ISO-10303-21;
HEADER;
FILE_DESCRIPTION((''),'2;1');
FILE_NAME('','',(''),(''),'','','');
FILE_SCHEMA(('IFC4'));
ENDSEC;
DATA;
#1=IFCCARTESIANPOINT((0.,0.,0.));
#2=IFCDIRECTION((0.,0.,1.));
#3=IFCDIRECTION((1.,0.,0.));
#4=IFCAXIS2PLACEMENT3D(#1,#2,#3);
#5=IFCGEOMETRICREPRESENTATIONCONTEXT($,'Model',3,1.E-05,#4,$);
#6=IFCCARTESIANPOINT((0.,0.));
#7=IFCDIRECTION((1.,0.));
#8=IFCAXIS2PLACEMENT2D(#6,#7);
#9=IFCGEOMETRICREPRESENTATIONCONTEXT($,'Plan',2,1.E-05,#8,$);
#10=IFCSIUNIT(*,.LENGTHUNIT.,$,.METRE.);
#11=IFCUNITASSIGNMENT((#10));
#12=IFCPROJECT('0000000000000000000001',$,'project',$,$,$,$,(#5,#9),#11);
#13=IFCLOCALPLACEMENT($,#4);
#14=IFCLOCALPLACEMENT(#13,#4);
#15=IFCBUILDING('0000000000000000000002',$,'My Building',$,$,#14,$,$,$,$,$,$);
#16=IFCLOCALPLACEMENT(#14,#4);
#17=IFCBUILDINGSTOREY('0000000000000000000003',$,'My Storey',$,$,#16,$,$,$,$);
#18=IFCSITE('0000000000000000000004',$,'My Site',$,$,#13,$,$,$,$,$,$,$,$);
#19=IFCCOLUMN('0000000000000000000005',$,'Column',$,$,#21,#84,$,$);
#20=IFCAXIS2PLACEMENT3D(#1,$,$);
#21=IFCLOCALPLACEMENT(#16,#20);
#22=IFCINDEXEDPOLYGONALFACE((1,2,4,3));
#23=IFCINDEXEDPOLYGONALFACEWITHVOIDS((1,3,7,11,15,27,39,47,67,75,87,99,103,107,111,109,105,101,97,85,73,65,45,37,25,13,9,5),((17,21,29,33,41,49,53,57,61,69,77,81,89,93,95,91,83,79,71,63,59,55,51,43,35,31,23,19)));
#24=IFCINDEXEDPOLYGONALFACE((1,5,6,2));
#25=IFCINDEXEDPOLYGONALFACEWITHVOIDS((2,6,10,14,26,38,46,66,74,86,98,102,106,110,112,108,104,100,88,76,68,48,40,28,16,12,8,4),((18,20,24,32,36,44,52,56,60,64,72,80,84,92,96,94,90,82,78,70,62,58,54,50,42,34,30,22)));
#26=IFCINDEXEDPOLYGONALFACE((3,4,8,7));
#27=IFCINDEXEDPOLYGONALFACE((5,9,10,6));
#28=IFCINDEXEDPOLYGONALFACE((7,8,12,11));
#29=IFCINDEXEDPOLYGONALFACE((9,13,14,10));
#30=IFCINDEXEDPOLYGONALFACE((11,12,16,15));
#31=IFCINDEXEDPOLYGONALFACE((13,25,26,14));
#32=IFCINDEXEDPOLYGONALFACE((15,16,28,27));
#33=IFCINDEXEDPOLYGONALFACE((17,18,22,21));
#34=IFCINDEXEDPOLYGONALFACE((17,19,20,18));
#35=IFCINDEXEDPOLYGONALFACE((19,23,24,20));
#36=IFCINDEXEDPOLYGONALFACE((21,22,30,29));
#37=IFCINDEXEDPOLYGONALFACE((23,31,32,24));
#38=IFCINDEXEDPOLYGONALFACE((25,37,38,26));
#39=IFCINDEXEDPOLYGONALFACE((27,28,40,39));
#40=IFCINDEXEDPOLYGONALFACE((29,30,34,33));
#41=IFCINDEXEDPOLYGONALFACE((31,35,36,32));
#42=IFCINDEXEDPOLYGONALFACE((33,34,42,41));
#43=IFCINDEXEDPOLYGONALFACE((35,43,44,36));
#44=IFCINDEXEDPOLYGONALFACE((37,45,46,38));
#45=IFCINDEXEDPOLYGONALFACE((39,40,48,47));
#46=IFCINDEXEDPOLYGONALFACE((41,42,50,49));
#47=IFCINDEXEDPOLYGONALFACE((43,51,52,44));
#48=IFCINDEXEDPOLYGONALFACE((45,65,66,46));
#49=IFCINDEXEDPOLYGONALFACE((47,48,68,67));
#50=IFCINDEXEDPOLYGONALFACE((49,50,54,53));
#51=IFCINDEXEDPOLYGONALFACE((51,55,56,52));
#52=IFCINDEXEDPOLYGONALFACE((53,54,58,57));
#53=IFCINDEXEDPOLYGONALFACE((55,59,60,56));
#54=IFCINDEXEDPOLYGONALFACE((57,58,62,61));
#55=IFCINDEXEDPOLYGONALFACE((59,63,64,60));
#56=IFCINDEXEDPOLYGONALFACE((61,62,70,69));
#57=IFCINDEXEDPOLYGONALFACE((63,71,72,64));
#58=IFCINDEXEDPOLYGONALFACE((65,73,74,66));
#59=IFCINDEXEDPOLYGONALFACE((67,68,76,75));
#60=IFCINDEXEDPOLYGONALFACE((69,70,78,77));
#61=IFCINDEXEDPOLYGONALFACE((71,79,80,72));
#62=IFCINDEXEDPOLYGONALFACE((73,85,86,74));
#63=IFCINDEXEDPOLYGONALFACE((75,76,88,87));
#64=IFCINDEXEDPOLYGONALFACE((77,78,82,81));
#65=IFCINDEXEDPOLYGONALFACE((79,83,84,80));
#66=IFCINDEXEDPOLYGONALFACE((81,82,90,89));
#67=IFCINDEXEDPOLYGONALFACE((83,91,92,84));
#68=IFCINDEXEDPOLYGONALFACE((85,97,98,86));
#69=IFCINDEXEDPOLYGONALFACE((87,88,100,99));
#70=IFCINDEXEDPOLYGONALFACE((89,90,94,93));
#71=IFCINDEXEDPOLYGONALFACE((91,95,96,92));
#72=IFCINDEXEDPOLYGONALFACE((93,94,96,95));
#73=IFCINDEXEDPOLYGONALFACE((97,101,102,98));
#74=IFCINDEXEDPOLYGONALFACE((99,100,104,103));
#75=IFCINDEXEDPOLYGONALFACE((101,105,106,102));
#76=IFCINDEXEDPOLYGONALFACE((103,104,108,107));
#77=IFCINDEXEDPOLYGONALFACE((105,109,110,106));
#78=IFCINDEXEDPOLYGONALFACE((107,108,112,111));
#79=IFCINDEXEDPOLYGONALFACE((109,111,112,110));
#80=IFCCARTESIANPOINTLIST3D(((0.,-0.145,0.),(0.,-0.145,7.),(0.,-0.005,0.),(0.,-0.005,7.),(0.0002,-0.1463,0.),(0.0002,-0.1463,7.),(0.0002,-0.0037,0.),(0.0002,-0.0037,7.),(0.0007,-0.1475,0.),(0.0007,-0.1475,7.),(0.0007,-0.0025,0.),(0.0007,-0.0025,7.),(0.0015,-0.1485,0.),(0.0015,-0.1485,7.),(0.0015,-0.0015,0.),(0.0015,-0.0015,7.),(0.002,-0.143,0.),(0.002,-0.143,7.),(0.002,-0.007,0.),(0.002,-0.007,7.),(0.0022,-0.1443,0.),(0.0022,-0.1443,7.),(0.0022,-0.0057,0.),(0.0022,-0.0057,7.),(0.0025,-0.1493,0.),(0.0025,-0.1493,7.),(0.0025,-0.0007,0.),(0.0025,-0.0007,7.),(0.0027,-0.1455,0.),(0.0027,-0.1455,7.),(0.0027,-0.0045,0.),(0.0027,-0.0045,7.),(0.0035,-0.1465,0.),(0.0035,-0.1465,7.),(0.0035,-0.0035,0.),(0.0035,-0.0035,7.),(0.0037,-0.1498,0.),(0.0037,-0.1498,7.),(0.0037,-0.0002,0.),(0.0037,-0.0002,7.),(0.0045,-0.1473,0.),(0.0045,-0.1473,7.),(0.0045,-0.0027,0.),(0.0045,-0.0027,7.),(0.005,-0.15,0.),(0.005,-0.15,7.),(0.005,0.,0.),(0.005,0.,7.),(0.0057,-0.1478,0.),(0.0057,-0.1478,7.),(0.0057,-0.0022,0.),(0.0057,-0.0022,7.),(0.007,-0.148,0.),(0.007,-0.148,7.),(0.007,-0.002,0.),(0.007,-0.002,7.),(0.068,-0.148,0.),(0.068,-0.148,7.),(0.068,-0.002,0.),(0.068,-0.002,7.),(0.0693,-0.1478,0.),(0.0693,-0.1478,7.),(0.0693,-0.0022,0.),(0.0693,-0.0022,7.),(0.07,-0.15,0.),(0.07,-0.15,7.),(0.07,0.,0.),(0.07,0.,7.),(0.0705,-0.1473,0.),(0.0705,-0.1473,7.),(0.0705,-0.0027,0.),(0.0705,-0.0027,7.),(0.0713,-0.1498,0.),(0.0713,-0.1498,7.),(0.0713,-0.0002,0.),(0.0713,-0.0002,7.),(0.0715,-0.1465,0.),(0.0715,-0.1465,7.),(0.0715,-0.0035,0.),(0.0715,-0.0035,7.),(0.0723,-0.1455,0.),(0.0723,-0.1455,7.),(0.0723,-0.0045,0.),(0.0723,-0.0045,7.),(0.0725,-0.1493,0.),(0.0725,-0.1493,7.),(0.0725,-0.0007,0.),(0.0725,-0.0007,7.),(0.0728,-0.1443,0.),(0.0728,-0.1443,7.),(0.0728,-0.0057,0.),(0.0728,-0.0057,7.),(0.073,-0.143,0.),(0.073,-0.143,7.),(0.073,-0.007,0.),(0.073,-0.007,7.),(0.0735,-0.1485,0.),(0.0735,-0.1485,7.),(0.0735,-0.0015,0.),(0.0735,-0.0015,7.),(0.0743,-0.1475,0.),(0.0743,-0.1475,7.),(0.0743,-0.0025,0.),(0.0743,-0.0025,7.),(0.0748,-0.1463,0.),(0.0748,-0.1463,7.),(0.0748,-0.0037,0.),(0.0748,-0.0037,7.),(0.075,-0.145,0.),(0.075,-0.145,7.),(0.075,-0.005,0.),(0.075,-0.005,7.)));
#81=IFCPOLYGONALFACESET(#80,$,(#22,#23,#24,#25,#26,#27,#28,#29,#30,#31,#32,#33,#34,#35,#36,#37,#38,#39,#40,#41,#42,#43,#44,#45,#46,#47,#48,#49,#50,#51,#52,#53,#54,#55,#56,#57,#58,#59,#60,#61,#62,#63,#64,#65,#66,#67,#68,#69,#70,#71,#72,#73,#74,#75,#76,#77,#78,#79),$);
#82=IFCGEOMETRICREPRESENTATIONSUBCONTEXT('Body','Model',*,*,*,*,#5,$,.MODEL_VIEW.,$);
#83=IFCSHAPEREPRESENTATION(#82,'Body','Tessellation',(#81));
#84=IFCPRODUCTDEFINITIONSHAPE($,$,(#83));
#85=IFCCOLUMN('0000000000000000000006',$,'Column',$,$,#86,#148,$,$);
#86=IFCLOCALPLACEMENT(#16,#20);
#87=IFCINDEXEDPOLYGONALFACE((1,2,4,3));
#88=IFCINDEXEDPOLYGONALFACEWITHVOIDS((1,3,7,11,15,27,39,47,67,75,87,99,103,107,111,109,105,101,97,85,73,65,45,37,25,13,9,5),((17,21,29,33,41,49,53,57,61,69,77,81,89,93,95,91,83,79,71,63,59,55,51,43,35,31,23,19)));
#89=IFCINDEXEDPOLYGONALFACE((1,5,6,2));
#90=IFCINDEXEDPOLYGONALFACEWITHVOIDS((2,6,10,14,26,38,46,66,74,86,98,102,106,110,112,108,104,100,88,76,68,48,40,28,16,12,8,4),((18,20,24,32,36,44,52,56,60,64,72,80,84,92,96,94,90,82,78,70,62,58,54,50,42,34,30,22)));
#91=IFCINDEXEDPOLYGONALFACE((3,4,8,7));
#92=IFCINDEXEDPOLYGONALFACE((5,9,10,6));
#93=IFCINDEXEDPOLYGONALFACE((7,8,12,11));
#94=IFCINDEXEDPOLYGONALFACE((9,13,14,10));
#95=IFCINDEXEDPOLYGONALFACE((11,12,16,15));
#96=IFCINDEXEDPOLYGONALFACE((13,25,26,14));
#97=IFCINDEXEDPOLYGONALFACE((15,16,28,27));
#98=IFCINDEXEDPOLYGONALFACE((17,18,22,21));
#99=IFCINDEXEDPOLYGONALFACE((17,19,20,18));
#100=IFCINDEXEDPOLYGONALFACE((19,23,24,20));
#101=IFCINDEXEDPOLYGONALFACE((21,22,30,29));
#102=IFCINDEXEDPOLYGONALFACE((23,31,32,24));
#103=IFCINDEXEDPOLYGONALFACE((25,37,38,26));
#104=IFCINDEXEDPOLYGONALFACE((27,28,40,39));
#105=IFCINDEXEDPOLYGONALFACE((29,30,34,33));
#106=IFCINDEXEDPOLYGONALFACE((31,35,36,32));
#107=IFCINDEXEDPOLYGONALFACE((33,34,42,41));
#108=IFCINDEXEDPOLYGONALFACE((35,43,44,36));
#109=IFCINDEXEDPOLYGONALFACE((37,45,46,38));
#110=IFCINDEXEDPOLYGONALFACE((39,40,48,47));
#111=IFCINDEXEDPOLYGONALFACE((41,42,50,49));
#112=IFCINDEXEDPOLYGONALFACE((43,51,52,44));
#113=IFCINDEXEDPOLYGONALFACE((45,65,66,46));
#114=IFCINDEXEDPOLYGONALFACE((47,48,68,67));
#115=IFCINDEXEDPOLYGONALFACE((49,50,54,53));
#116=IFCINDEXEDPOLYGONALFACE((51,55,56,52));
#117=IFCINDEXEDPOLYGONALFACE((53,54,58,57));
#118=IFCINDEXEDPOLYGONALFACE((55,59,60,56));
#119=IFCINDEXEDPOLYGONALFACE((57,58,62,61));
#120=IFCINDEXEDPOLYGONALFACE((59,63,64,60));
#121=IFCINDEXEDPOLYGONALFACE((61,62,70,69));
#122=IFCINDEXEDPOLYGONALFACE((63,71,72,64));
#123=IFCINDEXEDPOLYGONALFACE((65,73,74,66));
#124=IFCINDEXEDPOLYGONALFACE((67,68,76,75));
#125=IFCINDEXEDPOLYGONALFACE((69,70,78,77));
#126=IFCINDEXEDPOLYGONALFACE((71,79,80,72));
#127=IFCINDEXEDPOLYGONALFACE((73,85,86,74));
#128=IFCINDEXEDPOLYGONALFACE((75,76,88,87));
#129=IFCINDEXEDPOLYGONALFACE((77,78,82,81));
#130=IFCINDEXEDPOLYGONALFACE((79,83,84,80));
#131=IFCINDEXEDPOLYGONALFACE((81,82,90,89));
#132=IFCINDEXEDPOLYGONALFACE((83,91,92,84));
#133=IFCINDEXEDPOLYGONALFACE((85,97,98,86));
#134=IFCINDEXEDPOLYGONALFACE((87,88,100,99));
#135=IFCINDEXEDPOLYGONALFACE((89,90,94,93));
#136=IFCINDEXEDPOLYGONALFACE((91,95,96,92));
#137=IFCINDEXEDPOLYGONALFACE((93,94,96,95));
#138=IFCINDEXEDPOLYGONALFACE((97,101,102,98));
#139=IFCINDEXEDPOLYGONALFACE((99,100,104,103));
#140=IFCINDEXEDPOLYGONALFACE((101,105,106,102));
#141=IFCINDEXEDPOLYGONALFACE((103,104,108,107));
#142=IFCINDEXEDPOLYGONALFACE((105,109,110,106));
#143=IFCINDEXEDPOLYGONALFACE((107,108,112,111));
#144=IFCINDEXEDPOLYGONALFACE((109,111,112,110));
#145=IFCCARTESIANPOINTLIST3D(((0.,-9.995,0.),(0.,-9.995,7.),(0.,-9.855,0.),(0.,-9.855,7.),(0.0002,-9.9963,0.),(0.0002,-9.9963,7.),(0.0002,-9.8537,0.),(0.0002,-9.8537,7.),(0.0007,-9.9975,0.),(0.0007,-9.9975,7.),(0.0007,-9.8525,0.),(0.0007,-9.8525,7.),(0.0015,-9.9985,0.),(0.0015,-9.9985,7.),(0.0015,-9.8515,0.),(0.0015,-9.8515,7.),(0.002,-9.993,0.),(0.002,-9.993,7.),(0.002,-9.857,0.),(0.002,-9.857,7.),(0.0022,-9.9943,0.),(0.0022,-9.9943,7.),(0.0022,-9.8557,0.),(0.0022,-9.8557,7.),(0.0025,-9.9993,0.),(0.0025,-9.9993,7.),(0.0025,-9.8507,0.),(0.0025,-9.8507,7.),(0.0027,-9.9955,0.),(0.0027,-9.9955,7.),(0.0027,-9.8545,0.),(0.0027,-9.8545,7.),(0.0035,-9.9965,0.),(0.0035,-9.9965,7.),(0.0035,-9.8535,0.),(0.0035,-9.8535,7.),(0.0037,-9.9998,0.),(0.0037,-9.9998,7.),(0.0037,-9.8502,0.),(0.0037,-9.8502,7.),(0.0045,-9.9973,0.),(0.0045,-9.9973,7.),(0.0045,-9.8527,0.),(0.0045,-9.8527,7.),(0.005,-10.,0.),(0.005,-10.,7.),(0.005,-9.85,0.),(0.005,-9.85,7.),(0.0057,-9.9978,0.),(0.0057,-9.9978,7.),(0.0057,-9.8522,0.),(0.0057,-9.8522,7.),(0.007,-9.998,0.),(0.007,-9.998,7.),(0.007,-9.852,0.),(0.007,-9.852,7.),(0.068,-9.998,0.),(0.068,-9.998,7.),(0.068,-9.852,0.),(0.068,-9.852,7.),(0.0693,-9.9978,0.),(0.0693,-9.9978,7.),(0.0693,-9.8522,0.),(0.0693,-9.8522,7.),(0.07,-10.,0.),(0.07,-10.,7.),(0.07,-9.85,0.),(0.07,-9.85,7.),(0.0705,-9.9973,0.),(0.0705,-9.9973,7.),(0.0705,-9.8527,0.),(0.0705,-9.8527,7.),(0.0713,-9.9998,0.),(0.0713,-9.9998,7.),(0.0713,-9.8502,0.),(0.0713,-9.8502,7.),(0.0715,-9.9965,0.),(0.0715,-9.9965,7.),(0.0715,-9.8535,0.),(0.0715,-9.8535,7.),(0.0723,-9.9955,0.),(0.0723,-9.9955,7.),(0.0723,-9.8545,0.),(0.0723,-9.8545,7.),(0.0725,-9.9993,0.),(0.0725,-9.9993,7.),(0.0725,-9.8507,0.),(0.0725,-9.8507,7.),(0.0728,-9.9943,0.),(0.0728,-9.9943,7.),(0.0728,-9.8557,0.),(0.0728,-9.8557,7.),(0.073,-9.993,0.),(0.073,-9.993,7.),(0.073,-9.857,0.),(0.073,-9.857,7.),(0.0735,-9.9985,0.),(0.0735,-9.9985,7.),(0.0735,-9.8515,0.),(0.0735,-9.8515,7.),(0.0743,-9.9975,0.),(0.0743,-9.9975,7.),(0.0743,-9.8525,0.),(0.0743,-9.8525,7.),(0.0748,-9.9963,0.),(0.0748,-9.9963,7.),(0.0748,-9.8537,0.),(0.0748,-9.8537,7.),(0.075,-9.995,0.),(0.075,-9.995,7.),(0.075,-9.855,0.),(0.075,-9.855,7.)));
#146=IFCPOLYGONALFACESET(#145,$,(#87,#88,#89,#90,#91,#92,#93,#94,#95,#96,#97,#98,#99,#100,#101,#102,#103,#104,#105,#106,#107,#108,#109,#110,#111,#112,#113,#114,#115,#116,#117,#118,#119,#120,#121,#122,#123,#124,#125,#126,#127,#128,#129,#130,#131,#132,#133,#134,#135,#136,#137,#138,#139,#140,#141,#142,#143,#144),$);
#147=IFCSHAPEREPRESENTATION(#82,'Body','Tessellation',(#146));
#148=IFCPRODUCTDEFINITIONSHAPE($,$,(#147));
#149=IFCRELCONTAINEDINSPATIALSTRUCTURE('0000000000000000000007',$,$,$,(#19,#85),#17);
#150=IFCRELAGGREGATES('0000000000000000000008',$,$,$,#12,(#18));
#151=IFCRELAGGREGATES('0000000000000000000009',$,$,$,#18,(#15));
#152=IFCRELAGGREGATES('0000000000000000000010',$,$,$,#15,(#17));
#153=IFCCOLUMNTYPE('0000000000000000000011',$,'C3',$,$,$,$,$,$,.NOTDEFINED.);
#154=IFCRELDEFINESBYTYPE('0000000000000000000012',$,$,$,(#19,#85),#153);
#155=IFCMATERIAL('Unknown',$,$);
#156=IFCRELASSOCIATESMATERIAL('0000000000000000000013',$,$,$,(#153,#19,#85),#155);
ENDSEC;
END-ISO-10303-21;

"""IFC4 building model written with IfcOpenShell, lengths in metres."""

from ifc_helpers import new_model, si_unit, frame, origin_with_axes, origin_2d_with_axis, place, context, subcontext, project, spatial, hollow_rectangle, extrude, material, material_profile, profile_set, profile_usage, type_object, element, save


model = new_model("IFC4")

# Units and contexts
model_context = context("Model", 3, precision=1e-05, world=origin_with_axes())
plan_context = context("Plan", 2, precision=1e-05, world=origin_2d_with_axis())
body_context = subcontext(model_context, "Body", "Model", "MODEL_VIEW")
ifc_project = project(units=[si_unit("LENGTHUNIT", "METRE")], contexts=[model_context, plan_context])

# Site, building, storey
site_placement = place(None, origin_with_axes())
site = spatial("IfcSite", under=ifc_project, at=site_placement, Name="My Site")
building_placement = place(site_placement, origin_with_axes())
building = spatial("IfcBuilding", under=site, at=building_placement, Name="My Building")
storey_placement = place(building_placement, origin_with_axes())
storey = spatial("IfcBuildingStorey", under=building, at=storey_placement, Name="My Storey")

# Columns
ifc_material = material(Name="Unknown")
ifc_material_profile_1 = material_profile(ifc_material, hollow_rectangle(XDim=0.075, YDim=0.15, WallThickness=0.002, InnerFilletRadius=0.005, OuterFilletRadius=0.005))
ifc_profile_set_1 = profile_set([ifc_material_profile_1])
ifc_profile_usage_1 = profile_usage(ifc_profile_set_1, cardinal=5)
column_type = type_object("IfcColumnType", Name="C3", PredefinedType="NOTDEFINED", material=ifc_profile_set_1)
column_1_placement = place(storey_placement, frame((0.0375, -0.075, 0.0), z_axis=(0.0, 0.0, 1.0), x_axis=(1.0, 0.0, 0.0)))
element("IfcColumn", 1, at=column_1_placement, inside=storey, type_object=column_type, material=ifc_profile_usage_1, Name="Column", context=body_context, shape_type="SweptSolid", body=[
    extrude(hollow_rectangle(XDim=0.075, YDim=0.15, WallThickness=0.002, InnerFilletRadius=0.005, OuterFilletRadius=0.005), origin_with_axes(), (0.0, 0.0, 1.0), 7.0),
])
ifc_profile_usage_2 = profile_usage(ifc_profile_set_1, cardinal=5)
column_2_placement = place(storey_placement, frame((0.0375, -9.925, 0.0), z_axis=(0.0, 0.0, 1.0), x_axis=(1.0, 0.0, 0.0)))
element("IfcColumn", 2, at=column_2_placement, inside=storey, type_object=column_type, material=ifc_profile_usage_2, Name="Column", context=body_context, shape_type="SweptSolid", body=[
    extrude(hollow_rectangle(XDim=0.075, YDim=0.15, WallThickness=0.002, InnerFilletRadius=0.005, OuterFilletRadius=0.005), origin_with_axes(), (0.0, 0.0, 1.0), 7.0),
])

save(model, "model.ifc")
